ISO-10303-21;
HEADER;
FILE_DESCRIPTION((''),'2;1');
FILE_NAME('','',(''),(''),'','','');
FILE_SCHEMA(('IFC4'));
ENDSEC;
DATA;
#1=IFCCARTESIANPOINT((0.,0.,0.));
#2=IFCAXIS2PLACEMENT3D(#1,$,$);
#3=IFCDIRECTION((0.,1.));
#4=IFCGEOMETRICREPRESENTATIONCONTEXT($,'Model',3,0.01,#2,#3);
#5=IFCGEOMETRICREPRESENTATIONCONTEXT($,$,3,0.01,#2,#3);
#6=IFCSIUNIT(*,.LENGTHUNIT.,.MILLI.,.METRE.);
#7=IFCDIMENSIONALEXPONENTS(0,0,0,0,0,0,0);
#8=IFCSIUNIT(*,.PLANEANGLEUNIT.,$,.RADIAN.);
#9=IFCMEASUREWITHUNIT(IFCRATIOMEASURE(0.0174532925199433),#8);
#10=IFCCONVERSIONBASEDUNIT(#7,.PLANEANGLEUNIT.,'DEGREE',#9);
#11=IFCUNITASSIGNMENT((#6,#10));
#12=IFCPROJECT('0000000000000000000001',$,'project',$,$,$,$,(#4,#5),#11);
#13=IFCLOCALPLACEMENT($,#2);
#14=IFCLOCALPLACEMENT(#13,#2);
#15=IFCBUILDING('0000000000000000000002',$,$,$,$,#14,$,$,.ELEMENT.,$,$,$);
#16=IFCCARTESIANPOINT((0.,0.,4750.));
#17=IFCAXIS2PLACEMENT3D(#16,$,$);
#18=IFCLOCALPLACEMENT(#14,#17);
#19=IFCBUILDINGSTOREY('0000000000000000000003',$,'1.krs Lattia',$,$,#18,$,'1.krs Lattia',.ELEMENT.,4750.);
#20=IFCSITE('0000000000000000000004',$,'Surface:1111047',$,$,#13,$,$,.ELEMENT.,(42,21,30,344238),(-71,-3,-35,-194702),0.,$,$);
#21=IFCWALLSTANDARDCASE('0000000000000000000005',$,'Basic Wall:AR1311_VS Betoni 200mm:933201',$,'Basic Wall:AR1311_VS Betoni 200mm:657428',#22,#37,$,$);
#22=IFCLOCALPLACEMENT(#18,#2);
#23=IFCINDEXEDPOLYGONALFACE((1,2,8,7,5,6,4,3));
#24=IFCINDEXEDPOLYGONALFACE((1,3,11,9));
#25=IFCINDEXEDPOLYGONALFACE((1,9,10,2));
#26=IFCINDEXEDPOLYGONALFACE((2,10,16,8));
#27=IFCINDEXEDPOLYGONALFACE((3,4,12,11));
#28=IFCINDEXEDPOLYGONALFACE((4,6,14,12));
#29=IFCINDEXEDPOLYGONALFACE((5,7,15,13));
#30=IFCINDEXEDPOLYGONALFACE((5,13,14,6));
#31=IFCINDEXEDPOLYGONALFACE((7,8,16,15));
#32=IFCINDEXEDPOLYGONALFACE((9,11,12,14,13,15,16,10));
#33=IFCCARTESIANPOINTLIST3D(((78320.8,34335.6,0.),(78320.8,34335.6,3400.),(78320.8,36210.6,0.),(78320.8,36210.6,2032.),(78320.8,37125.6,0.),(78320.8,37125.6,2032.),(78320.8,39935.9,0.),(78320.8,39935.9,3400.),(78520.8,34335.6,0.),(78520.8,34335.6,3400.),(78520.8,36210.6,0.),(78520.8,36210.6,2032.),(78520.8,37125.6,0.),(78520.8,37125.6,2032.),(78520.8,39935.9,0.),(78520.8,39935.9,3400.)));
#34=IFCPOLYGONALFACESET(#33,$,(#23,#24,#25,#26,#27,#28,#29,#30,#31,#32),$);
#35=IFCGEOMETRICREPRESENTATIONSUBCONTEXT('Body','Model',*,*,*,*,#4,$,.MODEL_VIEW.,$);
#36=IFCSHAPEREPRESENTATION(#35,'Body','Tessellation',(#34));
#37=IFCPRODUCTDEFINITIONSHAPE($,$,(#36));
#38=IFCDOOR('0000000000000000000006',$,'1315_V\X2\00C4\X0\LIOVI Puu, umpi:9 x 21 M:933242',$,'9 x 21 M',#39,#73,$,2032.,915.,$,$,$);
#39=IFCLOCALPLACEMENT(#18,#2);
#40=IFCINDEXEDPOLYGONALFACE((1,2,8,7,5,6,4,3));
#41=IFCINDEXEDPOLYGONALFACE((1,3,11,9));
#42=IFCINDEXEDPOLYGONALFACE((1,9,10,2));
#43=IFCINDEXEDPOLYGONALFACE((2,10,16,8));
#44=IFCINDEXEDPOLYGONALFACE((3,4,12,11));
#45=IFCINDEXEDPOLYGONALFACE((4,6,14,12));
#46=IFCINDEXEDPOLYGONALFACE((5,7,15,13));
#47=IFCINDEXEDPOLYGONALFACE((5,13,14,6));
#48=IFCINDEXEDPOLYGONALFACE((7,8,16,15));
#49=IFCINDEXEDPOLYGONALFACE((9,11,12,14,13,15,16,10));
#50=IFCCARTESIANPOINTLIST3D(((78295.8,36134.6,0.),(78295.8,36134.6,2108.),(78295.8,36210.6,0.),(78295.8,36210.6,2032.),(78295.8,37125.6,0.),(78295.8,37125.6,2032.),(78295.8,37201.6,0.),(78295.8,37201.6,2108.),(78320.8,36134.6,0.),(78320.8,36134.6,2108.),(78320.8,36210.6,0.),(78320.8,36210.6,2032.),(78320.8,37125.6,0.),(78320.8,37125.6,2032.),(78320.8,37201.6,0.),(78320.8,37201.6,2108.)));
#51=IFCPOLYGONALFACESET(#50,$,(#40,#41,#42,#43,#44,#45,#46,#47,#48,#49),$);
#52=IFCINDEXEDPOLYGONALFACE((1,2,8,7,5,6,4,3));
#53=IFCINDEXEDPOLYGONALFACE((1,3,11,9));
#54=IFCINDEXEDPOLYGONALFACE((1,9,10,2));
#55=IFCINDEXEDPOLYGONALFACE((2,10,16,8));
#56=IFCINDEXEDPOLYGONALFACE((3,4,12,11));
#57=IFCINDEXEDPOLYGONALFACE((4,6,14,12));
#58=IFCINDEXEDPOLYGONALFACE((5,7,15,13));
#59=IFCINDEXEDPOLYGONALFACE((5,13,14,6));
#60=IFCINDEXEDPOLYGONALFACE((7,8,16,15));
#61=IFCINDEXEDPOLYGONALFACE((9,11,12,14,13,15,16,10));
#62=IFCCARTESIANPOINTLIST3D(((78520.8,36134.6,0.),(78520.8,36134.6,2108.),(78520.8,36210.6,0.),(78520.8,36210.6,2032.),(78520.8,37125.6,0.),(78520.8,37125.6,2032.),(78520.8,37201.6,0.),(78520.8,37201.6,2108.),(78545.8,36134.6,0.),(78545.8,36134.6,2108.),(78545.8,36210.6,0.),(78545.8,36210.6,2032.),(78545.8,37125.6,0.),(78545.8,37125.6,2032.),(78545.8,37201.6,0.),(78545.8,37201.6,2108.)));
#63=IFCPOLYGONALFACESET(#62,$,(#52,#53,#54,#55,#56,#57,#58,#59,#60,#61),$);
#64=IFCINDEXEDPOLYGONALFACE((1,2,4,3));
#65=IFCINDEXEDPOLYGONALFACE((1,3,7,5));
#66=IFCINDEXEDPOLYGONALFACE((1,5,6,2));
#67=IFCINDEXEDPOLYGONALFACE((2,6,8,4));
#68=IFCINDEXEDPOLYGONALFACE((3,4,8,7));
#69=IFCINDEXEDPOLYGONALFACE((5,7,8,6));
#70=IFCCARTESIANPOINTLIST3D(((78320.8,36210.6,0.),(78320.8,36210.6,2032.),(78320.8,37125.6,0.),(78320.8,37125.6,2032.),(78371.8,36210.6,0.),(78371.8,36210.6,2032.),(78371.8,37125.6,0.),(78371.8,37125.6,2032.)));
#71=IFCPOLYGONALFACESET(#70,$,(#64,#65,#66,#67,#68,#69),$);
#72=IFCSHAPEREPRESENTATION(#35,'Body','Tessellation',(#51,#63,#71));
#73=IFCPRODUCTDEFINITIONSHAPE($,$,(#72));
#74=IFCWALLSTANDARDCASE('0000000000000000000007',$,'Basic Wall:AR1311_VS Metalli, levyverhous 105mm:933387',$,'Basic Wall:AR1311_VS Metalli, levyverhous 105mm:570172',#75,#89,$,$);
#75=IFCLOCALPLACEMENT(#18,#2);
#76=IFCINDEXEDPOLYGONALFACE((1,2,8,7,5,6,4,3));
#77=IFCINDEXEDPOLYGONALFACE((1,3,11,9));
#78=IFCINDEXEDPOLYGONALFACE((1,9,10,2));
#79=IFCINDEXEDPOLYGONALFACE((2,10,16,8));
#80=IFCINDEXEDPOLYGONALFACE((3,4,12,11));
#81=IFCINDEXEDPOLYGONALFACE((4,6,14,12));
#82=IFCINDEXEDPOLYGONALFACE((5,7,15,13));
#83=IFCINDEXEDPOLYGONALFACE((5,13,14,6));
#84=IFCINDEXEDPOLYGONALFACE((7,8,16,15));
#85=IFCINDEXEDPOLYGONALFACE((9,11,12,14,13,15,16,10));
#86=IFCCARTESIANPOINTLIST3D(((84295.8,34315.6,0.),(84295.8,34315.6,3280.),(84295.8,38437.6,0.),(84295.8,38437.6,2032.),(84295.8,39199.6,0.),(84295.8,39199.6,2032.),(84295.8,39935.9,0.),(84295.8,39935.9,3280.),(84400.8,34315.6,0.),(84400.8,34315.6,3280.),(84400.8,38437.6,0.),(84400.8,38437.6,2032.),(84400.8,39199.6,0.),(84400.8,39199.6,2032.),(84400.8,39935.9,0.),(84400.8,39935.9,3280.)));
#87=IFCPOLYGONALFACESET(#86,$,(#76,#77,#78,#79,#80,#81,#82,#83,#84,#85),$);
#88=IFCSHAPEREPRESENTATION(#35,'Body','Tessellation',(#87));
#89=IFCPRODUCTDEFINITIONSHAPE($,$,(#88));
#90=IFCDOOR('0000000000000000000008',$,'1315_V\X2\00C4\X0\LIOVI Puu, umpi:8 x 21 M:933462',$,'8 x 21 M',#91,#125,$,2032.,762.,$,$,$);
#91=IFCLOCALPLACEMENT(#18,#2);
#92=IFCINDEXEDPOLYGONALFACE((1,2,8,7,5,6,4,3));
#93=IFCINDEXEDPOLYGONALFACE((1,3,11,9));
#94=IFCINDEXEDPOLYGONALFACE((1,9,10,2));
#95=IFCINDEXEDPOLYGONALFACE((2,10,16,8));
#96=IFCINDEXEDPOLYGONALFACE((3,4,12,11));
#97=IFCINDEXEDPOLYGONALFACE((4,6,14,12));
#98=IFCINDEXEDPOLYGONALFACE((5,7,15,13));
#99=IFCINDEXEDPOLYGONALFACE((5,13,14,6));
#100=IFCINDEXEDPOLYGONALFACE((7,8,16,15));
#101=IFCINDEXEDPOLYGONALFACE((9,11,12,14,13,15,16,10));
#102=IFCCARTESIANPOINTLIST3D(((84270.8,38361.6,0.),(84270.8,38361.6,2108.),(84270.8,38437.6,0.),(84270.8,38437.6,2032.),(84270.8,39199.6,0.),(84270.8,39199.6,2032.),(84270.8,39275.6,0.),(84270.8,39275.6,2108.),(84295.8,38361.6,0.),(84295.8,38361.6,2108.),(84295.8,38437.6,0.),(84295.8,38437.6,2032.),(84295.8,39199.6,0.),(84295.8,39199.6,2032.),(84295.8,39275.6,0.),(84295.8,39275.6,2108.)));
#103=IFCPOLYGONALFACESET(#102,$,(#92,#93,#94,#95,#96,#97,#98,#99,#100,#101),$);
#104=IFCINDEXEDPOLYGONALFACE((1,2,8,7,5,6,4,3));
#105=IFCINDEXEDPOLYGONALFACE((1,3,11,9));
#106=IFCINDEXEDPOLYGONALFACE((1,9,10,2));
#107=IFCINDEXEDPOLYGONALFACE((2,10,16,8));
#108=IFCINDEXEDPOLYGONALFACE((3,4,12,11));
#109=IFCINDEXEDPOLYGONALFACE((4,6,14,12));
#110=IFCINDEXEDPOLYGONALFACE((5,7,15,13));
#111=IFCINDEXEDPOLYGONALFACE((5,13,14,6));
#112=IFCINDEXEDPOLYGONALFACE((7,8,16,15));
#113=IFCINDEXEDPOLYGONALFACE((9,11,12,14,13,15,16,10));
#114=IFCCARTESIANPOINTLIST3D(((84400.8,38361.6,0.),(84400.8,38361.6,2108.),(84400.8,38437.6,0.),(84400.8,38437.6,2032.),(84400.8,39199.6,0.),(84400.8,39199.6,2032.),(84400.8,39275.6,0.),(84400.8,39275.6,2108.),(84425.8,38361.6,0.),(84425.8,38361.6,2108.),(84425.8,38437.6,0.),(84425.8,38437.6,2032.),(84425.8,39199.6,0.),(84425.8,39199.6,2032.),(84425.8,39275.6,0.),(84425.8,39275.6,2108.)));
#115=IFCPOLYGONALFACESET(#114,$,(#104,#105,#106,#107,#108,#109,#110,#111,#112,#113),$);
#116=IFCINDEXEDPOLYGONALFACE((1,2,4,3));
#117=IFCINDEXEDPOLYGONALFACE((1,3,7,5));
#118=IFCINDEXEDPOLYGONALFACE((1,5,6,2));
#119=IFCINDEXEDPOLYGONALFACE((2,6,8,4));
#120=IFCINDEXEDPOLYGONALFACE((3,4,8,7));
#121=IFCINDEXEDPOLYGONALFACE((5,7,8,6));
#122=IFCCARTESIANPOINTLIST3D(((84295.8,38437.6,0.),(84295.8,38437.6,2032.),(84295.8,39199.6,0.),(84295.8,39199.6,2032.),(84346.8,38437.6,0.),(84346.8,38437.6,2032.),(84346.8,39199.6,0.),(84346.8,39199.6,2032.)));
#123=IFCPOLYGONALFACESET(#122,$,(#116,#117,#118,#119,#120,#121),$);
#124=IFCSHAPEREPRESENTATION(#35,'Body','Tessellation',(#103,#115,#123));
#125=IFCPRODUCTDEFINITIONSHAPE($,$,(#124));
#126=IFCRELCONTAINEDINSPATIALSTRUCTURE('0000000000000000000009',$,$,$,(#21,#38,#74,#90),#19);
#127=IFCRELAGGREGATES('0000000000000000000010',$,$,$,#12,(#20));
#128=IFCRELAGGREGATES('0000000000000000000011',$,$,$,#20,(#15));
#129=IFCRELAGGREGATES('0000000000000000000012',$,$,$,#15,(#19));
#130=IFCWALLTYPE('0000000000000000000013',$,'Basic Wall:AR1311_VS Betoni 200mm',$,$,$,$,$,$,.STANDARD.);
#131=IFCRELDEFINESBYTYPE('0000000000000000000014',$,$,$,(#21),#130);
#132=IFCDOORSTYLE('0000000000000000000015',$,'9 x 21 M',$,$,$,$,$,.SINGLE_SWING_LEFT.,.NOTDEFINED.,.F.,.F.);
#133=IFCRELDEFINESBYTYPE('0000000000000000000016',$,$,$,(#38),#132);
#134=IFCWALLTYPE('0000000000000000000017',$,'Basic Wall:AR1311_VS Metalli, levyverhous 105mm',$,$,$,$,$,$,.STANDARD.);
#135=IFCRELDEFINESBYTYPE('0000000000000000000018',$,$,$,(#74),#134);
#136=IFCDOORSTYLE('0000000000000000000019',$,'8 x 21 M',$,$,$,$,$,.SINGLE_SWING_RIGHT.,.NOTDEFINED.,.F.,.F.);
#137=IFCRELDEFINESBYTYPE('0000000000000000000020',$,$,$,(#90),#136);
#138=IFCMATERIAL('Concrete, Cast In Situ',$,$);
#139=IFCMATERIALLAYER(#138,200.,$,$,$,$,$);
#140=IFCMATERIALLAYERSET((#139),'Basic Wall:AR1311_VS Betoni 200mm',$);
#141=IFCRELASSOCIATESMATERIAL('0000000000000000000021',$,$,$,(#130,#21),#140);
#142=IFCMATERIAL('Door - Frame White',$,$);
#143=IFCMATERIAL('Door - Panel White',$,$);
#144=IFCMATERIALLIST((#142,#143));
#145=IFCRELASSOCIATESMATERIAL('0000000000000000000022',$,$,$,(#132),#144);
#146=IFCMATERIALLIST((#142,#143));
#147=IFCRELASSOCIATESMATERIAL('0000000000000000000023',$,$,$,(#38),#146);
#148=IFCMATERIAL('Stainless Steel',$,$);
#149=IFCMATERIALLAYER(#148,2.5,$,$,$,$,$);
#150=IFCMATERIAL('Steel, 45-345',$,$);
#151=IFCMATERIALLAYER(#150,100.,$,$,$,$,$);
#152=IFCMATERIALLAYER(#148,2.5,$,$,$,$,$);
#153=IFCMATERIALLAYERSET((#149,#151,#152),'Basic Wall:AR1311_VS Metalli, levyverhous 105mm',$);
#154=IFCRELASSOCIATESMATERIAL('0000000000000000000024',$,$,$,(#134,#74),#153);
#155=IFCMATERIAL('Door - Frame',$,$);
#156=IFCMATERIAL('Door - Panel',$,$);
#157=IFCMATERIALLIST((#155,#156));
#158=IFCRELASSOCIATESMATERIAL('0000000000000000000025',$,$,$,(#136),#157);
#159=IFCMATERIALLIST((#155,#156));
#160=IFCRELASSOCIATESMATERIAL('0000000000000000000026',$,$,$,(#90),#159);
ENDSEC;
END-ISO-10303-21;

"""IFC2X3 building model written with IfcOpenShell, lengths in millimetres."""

from ifc_helpers import new_model, entity, si_unit, converted_unit, direction, frame, frame_2d, origin, origin_2d_with_axis, place, context, subcontext, project, spatial, polyline, rectangle, outline, extrude, clip, bounded_halfspace, source, transform, mapped, material, material_list, layer, layer_set, layer_usage, type_object, type_shapes, element, fill, save


model = new_model("IFC2X3")

# Units and contexts
model_context = context("Model", 3, precision=0.01, world=origin(), true_north=direction((0.0, 1.0)))
context_of_model = context(None, 3, precision=0.01, world=origin(), true_north=direction((0.0, 1.0)))
body_context = subcontext(model_context, "Body", "Model", "MODEL_VIEW")
ifc_project = project(units=[si_unit("LENGTHUNIT", "METRE", prefix="MILLI"), converted_unit("PLANEANGLEUNIT", "DEGREE", entity("IfcRatioMeasure", 0.0174532925199433), si_unit("PLANEANGLEUNIT", "RADIAN"), dimensions=[0, 0, 0, 0, 0, 0, 0])], contexts=[model_context, context_of_model])

# Site, building, storey
site_placement = place(None, origin())
site = spatial("IfcSite", under=ifc_project, at=site_placement, Name="Surface:1111047", CompositionType="ELEMENT", RefLatitude=(42, 21, 30, 344238), RefLongitude=(-71, -3, -35, -194702), RefElevation=0.0)
building_placement = place(site_placement, origin())
building = spatial("IfcBuilding", under=site, at=building_placement, CompositionType="ELEMENT")
storey_placement = place(building_placement, frame((0.0, 0.0, 4750.0)))
storey = spatial("IfcBuildingStorey", under=building, at=storey_placement, Name="1.krs Lattia", LongName="1.krs Lattia", CompositionType="ELEMENT", Elevation=4750.0)

# Shared definitions
ifc_material_1 = material(Name="Door - Frame")
ifc_material_2 = material(Name="Door - Panel")

# Shared definitions
ifc_material_3 = material(Name="Concrete, Cast In Situ")

# Shared definitions
ifc_material_4 = material(Name="Door - Frame White")
ifc_material_5 = material(Name="Door - Panel White")

# Walls, openings, doors
ifc_layer_1 = layer(ifc_material_3, 200.0)
ifc_layer_set_1 = layer_set([ifc_layer_1], Name="Basic Wall:AR1311_VS Betoni 200mm")
ifc_layer_usage_1 = layer_usage(ifc_layer_set_1, "AXIS2", "NEGATIVE", 100.0)
wall_type_1 = type_object("IfcWallType", Name="Basic Wall:AR1311_VS Betoni 200mm", PredefinedType="STANDARD", material=ifc_layer_set_1)
wall_1_placement = place(storey_placement, frame((78420.8, 39935.9, 0.0), z_axis=(0.0, 0.0, 1.0), x_axis=(0.0, -1.0, 0.0)))
wall_1 = element("IfcWallStandardCase", 1, at=wall_1_placement, inside=storey, type_object=wall_type_1, material=ifc_layer_usage_1, Name="Basic Wall:AR1311_VS Betoni 200mm:933201", ObjectType="Basic Wall:AR1311_VS Betoni 200mm:657428", context=body_context, shape_type="SweptSolid", body=[
    extrude(rectangle(XDim=5600.3, YDim=200.0, at=frame_2d((2800.2, 0.0), x_axis=(-1.0, 0.0))), origin(), (0.0, 0.0, 1.0), 3400.0),
])
opening_1_placement = place(wall_1_placement, frame((3725.3, 100.0, 0.0)))
opening_1 = element("IfcOpeningElement", 2, at=opening_1_placement, cuts=wall_1, ObjectType="Opening", context=body_context, shape_type="SweptSolid", body=[
    extrude(rectangle(XDim=915.0, YDim=2032.0, at=frame_2d((1016.0, 457.5), x_axis=(0.0, -1.0))), frame((0.0, 0.0, 0.0), z_axis=(0.0, -1.0, 0.0), x_axis=(0.0, 0.0, 1.0)), (0.0, 0.0, 1.0), 200.0),
])
ifc_material_list_1 = material_list([ifc_material_4, ifc_material_5])
ifc_material_list_2 = material_list([ifc_material_4, ifc_material_5])
door_style_1 = type_object("IfcDoorStyle", Name="9 x 21 M", ConstructionType="NOTDEFINED", OperationType="SINGLE_SWING_LEFT", ParameterTakesPrecedence=False, Sizeable=False, material=ifc_material_list_2)
shared_shape_1 = source(origin(), body_context, "Body", "SweptSolid", [
    extrude(outline(polyline([(-533.5, -1073.0), (533.5, -1073.0), (533.5, 1035.0), (457.5, 1035.0), (457.5, -997.0), (-457.5, -997.0), (-457.5, 1035.0), (-533.5, 1035.0), (-533.5, -1073.0)])), frame((457.5, 225.0, 1035.0), z_axis=(0.0, -1.0, 0.0), x_axis=(-1.0, 0.0, 0.0)), (0.0, 0.0, 1.0), 25.0),
    extrude(outline(polyline([(-1073.0, -533.5), (1035.0, -533.5), (1035.0, -457.5), (-997.0, -457.5), (-997.0, 457.5), (1035.0, 457.5), (1035.0, 533.5), (-1073.0, 533.5), (-1073.0, -533.5)])), frame((457.5, 0.0, 1035.0), z_axis=(0.0, -1.0, 0.0), x_axis=(0.0, 0.0, -1.0)), (0.0, 0.0, 1.0), 25.0),
    extrude(rectangle(XDim=915.0, YDim=51.0, at=frame_2d((0.0, 0.0), x_axis=(1.0, 0.0))), frame((457.5, 174.5, 0.0)), (0.0, 0.0, 1.0), 2032.0),
])
type_shapes(door_style_1, [shared_shape_1])
door_1_placement = place(opening_1_placement, frame((0.0, 0.0, 0.0), z_axis=(0.0, 0.0, 1.0), x_axis=(-1.0, 0.0, 0.0)))
door_1 = element("IfcDoor", 3, at=door_1_placement, inside=storey, type_object=door_style_1, material=ifc_material_list_1, Name="1315_VÄLIOVI Puu, umpi:9 x 21 M:933242", ObjectType="9 x 21 M", OverallHeight=2032.0, OverallWidth=915.0, context=body_context, shape_type="MappedRepresentation", body=[
    mapped(shared_shape_1, transform((0.0, 0.0, 0.0), scale=1.0)),
])
fill(opening_1, door_1)
ifc_material_6 = material(Name="Stainless Steel")
ifc_layer_2 = layer(ifc_material_6, 2.5)
ifc_material_7 = material(Name="Steel, 45-345")
ifc_layer_3 = layer(ifc_material_7, 100.0)
ifc_layer_4 = layer(ifc_material_6, 2.5)
ifc_layer_set_2 = layer_set([ifc_layer_2, ifc_layer_3, ifc_layer_4], Name="Basic Wall:AR1311_VS Metalli, levyverhous 105mm")
ifc_layer_usage_2 = layer_usage(ifc_layer_set_2, "AXIS2", "NEGATIVE", 52.5)
wall_type_2 = type_object("IfcWallType", Name="Basic Wall:AR1311_VS Metalli, levyverhous 105mm", PredefinedType="STANDARD", material=ifc_layer_set_2)
wall_2_placement = place(storey_placement, frame((84348.3, 39935.9, 0.0), z_axis=(0.0, 0.0, 1.0), x_axis=(0.0, -1.0, 0.0)))
wall_2 = element("IfcWallStandardCase", 4, at=wall_2_placement, inside=storey, type_object=wall_type_2, material=ifc_layer_usage_2, Name="Basic Wall:AR1311_VS Metalli, levyverhous 105mm:933387", ObjectType="Basic Wall:AR1311_VS Metalli, levyverhous 105mm:570172", context=body_context, shape_type="Clipping", body=[
    clip(extrude(rectangle(XDim=5620.3, YDim=105.0, at=frame_2d((2810.2, 0.0), x_axis=(1.0, 0.0))), origin(), (0.0, 0.0, 1.0), 3280.0), bounded_halfspace(frame((0.0, -52.5, 3280.0), z_axis=(0.0, 0.0, -1.0), x_axis=(0.0, -1.0, 0.0)), True, frame((0.0, -52.5, 3280.0)), polyline([(0.0, 0.0), (5620.3, 0.0), (5620.3, 105.0), (0.0, 105.0), (0.0, 0.0)]))),
])
opening_2_placement = place(wall_2_placement, frame((1498.3, 52.5, 0.0)))
opening_2 = element("IfcOpeningElement", 5, at=opening_2_placement, cuts=wall_2, ObjectType="Opening", context=body_context, shape_type="SweptSolid", body=[
    extrude(rectangle(XDim=762.0, YDim=2032.0, at=frame_2d((1016.0, 381.0), x_axis=(0.0, 1.0))), frame((0.0, 0.0, 0.0), z_axis=(0.0, -1.0, 0.0), x_axis=(0.0, 0.0, 1.0)), (0.0, 0.0, 1.0), 105.0),
])
ifc_material_list_3 = material_list([ifc_material_1, ifc_material_2])
ifc_material_list_4 = material_list([ifc_material_1, ifc_material_2])
door_style_2 = type_object("IfcDoorStyle", Name="8 x 21 M", ConstructionType="NOTDEFINED", OperationType="SINGLE_SWING_RIGHT", ParameterTakesPrecedence=False, Sizeable=False, material=ifc_material_list_4)
shared_shape_2 = source(origin(), body_context, "Body", "SweptSolid", [
    extrude(outline(polyline([(-457.0, -1073.0), (457.0, -1073.0), (457.0, 1035.0), (381.0, 1035.0), (381.0, -997.0), (-381.0, -997.0), (-381.0, 1035.0), (-457.0, 1035.0), (-457.0, -1073.0)])), frame((381.0, 105.0, 1035.0), z_axis=(0.0, 1.0, 0.0), x_axis=(1.0, 0.0, 0.0)), (0.0, 0.0, 1.0), 25.0),
    extrude(outline(polyline([(-1073.0, -457.0), (1035.0, -457.0), (1035.0, -381.0), (-997.0, -381.0), (-997.0, 381.0), (1035.0, 381.0), (1035.0, 457.0), (-1073.0, 457.0), (-1073.0, -457.0)])), frame((381.0, -25.0, 1035.0), z_axis=(0.0, 1.0, 0.0), x_axis=(0.0, 0.0, -1.0)), (0.0, 0.0, 1.0), 25.0),
    extrude(rectangle(XDim=51.0, YDim=762.0, at=origin_2d_with_axis()), frame((381.0, 79.5, 0.0), z_axis=(0.0, 0.0, 1.0), x_axis=(0.0, 1.0, 0.0)), (0.0, 0.0, 1.0), 2032.0),
])
type_shapes(door_style_2, [shared_shape_2])
door_2_placement = place(opening_2_placement, frame((0.0, 0.0, 0.0), z_axis=(0.0, 0.0, 1.0), x_axis=(-1.0, 0.0, 0.0)))
door_2 = element("IfcDoor", 6, at=door_2_placement, inside=storey, type_object=door_style_2, material=ifc_material_list_3, Name="1315_VÄLIOVI Puu, umpi:8 x 21 M:933462", ObjectType="8 x 21 M", OverallHeight=2032.0, OverallWidth=762.0, context=body_context, shape_type="MappedRepresentation", body=[
    mapped(shared_shape_2, transform((0.0, 0.0, 0.0), scale=1.0)),
])
fill(opening_2, door_2)

save(model, "model.ifc")
